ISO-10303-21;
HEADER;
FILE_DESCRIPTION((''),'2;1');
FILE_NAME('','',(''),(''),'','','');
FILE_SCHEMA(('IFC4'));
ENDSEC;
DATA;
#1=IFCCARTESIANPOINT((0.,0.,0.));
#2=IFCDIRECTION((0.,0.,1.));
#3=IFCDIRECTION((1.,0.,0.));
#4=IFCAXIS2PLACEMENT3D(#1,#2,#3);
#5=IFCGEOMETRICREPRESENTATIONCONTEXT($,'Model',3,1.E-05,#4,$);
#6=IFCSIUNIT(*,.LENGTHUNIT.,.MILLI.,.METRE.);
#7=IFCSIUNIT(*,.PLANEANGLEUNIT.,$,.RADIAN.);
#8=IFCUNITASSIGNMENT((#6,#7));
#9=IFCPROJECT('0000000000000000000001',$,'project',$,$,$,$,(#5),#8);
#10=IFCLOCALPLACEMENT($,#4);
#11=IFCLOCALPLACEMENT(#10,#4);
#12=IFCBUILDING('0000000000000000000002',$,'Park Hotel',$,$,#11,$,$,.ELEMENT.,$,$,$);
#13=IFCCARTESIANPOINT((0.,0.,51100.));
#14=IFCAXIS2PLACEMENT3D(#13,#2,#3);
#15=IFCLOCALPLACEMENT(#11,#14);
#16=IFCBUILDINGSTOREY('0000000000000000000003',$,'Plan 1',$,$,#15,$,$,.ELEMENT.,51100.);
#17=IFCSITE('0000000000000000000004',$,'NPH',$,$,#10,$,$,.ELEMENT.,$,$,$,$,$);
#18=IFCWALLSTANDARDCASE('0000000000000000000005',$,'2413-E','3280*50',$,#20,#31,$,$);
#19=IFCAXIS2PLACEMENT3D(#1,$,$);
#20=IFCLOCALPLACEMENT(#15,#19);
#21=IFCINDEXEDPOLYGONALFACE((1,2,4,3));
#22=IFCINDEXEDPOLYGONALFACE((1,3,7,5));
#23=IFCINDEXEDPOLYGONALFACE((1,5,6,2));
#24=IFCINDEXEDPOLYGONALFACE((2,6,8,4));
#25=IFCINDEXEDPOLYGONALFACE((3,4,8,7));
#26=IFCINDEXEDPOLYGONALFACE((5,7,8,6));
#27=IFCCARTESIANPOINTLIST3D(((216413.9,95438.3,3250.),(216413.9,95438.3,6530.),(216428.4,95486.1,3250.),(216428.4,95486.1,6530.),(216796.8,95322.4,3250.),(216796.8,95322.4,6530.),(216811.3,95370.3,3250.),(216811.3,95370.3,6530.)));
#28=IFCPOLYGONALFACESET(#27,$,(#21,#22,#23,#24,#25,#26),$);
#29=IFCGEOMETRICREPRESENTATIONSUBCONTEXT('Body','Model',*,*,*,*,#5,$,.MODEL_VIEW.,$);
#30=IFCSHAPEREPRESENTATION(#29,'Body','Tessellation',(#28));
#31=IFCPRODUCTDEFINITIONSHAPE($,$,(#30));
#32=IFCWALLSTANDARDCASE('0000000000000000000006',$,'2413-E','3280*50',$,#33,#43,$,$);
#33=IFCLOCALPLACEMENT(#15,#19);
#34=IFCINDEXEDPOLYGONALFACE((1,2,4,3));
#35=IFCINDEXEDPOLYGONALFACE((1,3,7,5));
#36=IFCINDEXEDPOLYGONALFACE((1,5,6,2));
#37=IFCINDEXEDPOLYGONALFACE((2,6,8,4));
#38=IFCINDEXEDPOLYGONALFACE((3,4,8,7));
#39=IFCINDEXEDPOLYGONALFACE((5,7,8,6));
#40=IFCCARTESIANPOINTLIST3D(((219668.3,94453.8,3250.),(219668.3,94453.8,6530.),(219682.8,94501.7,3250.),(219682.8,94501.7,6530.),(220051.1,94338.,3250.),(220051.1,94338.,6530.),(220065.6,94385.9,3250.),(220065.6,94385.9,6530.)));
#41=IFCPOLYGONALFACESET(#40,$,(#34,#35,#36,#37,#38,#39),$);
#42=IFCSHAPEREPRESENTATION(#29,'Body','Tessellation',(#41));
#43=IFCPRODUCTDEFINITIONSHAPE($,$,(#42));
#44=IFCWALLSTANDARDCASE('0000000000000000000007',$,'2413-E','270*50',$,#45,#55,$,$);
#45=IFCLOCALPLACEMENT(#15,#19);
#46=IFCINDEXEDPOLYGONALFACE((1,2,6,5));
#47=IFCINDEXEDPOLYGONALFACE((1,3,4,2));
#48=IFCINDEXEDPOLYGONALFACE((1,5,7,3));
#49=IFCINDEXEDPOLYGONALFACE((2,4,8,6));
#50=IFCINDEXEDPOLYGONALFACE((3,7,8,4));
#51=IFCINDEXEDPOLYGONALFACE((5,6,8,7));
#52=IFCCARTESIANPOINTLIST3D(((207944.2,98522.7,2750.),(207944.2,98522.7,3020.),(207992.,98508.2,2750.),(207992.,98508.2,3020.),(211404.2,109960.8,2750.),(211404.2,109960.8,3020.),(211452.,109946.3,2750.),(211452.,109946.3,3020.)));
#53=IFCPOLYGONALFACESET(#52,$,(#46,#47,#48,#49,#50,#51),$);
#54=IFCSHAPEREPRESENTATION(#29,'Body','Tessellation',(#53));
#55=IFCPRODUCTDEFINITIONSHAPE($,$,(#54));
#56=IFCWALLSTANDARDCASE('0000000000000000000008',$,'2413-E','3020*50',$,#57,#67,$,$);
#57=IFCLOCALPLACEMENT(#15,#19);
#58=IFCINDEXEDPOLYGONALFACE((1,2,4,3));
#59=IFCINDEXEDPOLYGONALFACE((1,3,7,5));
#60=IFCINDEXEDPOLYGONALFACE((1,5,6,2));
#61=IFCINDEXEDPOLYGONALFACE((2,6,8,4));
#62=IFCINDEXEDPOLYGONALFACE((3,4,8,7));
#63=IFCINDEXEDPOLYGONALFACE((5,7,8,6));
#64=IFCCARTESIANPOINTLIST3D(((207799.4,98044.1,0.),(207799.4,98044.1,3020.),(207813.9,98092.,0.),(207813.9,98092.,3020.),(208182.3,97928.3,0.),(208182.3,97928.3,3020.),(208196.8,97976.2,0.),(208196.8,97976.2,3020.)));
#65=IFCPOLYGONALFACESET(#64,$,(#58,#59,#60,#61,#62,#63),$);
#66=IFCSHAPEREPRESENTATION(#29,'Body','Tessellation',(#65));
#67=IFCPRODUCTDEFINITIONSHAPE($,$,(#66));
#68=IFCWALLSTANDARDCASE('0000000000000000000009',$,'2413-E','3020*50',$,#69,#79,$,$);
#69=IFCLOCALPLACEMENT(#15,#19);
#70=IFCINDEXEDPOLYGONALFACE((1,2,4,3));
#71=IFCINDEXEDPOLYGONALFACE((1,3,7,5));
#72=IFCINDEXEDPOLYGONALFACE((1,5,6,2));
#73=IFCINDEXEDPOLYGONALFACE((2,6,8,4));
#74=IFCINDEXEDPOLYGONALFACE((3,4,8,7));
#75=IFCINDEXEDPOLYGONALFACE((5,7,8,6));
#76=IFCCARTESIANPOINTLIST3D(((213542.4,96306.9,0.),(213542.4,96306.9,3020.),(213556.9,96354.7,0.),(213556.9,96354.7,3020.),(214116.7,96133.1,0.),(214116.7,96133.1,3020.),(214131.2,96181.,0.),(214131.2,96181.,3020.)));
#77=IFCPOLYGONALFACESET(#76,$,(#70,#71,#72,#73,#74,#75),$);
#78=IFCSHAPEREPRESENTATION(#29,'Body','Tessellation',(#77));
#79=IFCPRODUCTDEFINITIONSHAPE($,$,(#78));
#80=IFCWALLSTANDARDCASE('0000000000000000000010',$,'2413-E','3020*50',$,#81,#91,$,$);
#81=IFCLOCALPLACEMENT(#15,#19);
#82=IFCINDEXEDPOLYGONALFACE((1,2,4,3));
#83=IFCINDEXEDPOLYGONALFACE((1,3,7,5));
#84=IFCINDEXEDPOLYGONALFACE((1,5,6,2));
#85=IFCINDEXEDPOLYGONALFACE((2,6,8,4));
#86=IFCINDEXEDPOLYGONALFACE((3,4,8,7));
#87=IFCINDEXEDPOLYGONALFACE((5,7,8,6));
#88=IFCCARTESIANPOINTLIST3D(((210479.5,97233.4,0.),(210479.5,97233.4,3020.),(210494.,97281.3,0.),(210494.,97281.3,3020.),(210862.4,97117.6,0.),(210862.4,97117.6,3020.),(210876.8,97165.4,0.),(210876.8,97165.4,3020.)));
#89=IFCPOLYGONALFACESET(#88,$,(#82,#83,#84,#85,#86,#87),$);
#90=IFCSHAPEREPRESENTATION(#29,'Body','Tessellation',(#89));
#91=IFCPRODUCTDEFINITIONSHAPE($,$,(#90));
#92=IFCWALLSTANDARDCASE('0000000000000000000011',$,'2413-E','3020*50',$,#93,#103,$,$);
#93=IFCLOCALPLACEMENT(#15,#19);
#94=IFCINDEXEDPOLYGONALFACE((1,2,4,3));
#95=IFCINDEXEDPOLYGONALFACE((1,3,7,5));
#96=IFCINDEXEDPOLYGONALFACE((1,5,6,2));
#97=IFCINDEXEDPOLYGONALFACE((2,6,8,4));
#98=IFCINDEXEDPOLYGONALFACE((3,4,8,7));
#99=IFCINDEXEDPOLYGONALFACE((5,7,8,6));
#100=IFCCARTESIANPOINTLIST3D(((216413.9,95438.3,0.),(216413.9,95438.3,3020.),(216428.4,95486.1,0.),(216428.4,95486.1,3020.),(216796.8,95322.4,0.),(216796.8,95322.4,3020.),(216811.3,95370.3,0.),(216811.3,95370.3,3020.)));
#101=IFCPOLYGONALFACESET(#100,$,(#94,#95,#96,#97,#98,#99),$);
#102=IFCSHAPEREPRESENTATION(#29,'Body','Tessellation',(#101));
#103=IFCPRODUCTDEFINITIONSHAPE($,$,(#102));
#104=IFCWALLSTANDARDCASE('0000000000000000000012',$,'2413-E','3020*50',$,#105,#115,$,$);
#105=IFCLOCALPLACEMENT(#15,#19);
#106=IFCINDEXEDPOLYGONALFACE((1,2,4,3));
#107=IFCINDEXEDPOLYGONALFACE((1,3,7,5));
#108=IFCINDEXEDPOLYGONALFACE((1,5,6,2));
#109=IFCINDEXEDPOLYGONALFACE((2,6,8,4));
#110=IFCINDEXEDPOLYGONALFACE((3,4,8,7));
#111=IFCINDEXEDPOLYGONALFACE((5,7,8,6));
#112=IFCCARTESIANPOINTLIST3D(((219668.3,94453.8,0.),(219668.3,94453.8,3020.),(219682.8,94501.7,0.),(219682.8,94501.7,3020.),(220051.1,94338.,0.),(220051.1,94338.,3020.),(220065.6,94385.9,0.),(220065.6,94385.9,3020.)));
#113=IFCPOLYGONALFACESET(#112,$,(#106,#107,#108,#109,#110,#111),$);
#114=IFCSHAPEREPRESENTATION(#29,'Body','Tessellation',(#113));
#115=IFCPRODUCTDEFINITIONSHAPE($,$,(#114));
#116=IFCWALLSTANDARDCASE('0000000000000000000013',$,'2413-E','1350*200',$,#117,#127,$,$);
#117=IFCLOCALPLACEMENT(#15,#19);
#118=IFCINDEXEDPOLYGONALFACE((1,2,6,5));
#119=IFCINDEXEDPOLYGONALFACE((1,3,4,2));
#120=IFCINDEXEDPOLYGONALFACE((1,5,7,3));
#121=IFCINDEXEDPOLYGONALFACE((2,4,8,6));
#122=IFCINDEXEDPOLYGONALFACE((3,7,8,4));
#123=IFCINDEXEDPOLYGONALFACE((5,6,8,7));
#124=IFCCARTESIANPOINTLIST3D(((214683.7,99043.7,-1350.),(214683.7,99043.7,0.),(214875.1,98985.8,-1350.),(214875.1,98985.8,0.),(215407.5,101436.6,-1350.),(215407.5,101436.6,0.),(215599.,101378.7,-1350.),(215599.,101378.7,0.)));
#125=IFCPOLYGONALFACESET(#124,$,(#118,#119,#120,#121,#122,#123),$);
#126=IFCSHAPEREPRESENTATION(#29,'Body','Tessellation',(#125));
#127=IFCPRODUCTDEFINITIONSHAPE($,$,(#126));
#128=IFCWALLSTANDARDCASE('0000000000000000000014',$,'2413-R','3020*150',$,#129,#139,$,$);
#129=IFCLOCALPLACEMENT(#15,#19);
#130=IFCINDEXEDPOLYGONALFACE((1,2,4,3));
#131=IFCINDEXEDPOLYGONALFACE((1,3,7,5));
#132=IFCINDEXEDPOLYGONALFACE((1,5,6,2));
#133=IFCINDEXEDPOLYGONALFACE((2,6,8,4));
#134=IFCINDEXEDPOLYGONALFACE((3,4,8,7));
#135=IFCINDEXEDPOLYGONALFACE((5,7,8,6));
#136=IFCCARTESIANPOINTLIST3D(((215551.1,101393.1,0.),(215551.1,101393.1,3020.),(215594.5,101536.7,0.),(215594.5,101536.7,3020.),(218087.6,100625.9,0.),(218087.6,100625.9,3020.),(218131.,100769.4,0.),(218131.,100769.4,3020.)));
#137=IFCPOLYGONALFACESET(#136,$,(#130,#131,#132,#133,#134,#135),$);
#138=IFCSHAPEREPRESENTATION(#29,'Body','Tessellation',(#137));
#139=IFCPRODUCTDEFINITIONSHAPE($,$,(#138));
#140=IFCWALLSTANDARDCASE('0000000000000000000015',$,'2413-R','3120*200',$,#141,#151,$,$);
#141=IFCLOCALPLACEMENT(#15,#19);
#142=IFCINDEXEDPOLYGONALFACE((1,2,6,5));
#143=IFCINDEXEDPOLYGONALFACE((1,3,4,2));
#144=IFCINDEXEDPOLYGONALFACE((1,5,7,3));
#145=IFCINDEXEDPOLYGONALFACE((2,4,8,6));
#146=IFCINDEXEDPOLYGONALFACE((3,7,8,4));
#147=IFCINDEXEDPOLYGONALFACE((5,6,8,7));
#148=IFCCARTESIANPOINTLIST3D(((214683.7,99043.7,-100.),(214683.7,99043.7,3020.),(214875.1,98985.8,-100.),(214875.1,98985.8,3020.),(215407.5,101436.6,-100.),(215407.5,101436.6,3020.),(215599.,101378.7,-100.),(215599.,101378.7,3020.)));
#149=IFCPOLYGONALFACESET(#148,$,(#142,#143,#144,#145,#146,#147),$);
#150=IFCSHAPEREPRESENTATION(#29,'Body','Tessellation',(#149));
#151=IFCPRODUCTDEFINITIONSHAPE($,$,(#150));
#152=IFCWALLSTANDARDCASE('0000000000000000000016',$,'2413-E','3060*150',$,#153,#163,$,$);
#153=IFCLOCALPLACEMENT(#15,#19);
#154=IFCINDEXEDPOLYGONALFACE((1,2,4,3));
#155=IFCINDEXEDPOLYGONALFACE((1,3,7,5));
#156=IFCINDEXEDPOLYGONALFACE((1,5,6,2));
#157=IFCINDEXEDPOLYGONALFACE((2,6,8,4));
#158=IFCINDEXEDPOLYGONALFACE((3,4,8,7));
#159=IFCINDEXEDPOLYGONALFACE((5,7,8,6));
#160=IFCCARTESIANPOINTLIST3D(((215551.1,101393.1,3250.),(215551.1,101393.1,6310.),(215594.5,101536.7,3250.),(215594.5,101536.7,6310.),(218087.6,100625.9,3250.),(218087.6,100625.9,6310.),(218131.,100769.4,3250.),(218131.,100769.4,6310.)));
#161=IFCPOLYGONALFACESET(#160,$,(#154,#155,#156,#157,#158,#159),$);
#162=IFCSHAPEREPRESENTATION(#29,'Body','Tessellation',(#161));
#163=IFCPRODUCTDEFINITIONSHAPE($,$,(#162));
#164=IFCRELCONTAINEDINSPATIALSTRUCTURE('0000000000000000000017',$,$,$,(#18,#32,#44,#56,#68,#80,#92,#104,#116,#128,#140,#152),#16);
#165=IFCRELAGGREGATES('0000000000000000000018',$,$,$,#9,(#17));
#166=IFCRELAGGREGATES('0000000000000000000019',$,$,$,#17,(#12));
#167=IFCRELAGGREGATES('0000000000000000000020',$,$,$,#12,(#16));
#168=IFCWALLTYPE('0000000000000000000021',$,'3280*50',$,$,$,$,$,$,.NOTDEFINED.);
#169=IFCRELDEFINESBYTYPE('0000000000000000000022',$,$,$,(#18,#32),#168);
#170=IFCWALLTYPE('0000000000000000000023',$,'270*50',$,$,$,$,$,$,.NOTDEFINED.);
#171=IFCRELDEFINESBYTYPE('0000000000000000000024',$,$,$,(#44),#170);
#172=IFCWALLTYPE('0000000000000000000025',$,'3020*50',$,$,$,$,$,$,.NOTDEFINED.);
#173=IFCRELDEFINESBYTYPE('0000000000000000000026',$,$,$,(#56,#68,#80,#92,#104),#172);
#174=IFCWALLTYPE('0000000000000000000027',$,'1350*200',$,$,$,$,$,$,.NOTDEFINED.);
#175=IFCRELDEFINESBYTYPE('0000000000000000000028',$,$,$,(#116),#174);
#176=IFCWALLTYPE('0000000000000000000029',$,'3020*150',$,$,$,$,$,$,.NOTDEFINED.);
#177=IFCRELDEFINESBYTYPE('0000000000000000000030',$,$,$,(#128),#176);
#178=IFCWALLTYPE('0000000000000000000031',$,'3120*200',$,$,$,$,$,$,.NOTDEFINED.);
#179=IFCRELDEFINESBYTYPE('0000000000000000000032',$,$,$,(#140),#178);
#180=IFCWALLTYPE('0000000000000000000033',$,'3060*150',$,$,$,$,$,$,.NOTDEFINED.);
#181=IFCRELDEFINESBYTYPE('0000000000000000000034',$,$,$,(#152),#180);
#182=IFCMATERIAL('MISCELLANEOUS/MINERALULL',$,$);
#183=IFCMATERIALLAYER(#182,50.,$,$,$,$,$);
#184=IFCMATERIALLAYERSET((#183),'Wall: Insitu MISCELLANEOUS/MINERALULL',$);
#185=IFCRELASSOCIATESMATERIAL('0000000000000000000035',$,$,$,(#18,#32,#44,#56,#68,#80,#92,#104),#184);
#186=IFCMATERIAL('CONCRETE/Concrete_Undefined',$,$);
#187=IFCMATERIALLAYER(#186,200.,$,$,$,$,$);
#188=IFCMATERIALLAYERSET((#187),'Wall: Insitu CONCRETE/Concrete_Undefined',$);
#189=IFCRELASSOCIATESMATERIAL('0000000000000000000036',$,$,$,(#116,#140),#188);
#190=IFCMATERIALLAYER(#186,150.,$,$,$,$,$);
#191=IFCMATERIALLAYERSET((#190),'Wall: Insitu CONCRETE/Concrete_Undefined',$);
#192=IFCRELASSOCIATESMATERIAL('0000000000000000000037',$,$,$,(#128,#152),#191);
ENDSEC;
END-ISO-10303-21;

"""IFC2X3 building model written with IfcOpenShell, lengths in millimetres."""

from ifc_helpers import new_model, si_unit, frame, frame_2d, origin_with_axes, place, context, subcontext, project, spatial, rectangle, extrude, material, layer, layer_set, layer_usage, type_object, element, save


model = new_model("IFC2X3")

# Units and contexts
model_context = context("Model", 3, precision=1e-05, world=origin_with_axes())
body_context = subcontext(model_context, "Body", "Model", "MODEL_VIEW")
ifc_project = project(units=[si_unit("LENGTHUNIT", "METRE", prefix="MILLI"), si_unit("PLANEANGLEUNIT", "RADIAN")], contexts=[model_context])

# Site, building, storey
site_placement = place(None, origin_with_axes())
site = spatial("IfcSite", under=ifc_project, at=site_placement, Name="NPH", CompositionType="ELEMENT")
building_placement = place(site_placement, origin_with_axes())
building = spatial("IfcBuilding", under=site, at=building_placement, Name="Park Hotel", CompositionType="ELEMENT")
storey_placement = place(building_placement, frame((0.0, 0.0, 51100.0), z_axis=(0.0, 0.0, 1.0), x_axis=(1.0, 0.0, 0.0)))
storey = spatial("IfcBuildingStorey", under=building, at=storey_placement, Name="Plan 1", CompositionType="ELEMENT", Elevation=51100.0)

# Shared definitions
ifc_material_1 = material(Name="CONCRETE/Concrete_Undefined")

# Walls
ifc_material_2 = material(Name="MISCELLANEOUS/MINERALULL")
ifc_layer_1 = layer(ifc_material_2, 50.0)
ifc_layer_set_1 = layer_set([ifc_layer_1], Name="Wall: Insitu MISCELLANEOUS/MINERALULL")
wall_type_1 = type_object("IfcWallType", Name="3280*50", PredefinedType="NOTDEFINED")
ifc_layer_usage_1 = layer_usage(ifc_layer_set_1, "AXIS2", "POSITIVE", -25.0)
wall_1_placement = place(storey_placement, frame((216421.2, 95462.2, 3250.0), z_axis=(0.0, 0.0, 1.0), x_axis=(0.957166, -0.289539, 0.0)))
element("IfcWallStandardCase", 1, at=wall_1_placement, inside=storey, type_object=wall_type_1, material=ifc_layer_usage_1, Name="2413-E", Description="3280*50", context=body_context, shape_type="SweptSolid", body=[
    extrude(rectangle(XDim=400.0, YDim=50.0, at=frame_2d((0.0, 200.0), x_axis=(0.0, -1.0))), frame((0.0, 0.0, 0.0), z_axis=(0.0, 0.0, 1.0), x_axis=(0.0, -1.0, 0.0)), (0.0, 0.0, 1.0), 3280.0),
])
ifc_layer_usage_2 = layer_usage(ifc_layer_set_1, "AXIS2", "POSITIVE", -25.0)
wall_2_placement = place(storey_placement, frame((219675.5, 94477.8, 3250.0), z_axis=(0.0, 0.0, 1.0), x_axis=(0.957166, -0.289539, 0.0)))
element("IfcWallStandardCase", 2, at=wall_2_placement, inside=storey, type_object=wall_type_1, material=ifc_layer_usage_2, Name="2413-E", Description="3280*50", context=body_context, shape_type="SweptSolid", body=[
    extrude(rectangle(XDim=400.0, YDim=50.0, at=frame_2d((0.0, 200.0), x_axis=(0.0, -1.0))), frame((0.0, 0.0, 0.0), z_axis=(0.0, 0.0, 1.0), x_axis=(0.0, -1.0, 0.0)), (0.0, 0.0, 1.0), 3280.0),
])
ifc_layer_usage_3 = layer_usage(ifc_layer_set_1, "AXIS2", "POSITIVE", -25.0)
wall_type_2 = type_object("IfcWallType", Name="270*50", PredefinedType="NOTDEFINED")
wall_3_placement = place(storey_placement, frame((207968.1, 98515.4, 2750.0), z_axis=(0.0, 0.0, 1.0), x_axis=(0.289538, 0.957167, 0.0)))
element("IfcWallStandardCase", 3, at=wall_3_placement, inside=storey, type_object=wall_type_2, material=ifc_layer_usage_3, Name="2413-E", Description="270*50", context=body_context, shape_type="SweptSolid", body=[
    extrude(rectangle(XDim=11950.0, YDim=50.0, at=frame_2d((0.0, 5975.0), x_axis=(0.0, -1.0))), frame((0.0, 0.0, 0.0), z_axis=(0.0, 0.0, 1.0), x_axis=(0.0, -1.0, 0.0)), (0.0, 0.0, 1.0), 270.0),
])
ifc_layer_usage_4 = layer_usage(ifc_layer_set_1, "AXIS2", "POSITIVE", -25.0)
wall_type_3 = type_object("IfcWallType", Name="3020*50", PredefinedType="NOTDEFINED")
wall_4_placement = place(storey_placement, frame((207806.6, 98068.0, 0.0), z_axis=(0.0, 0.0, 1.0), x_axis=(0.957166, -0.289539, 0.0)))
element("IfcWallStandardCase", 4, at=wall_4_placement, inside=storey, type_object=wall_type_3, material=ifc_layer_usage_4, Name="2413-E", Description="3020*50", context=body_context, shape_type="SweptSolid", body=[
    extrude(rectangle(XDim=400.0, YDim=50.0, at=frame_2d((0.0, 200.0), x_axis=(0.0, -1.0))), frame((0.0, 0.0, 0.0), z_axis=(0.0, 0.0, 1.0), x_axis=(0.0, -1.0, 0.0)), (0.0, 0.0, 1.0), 3020.0),
])
ifc_layer_usage_5 = layer_usage(ifc_layer_set_1, "AXIS2", "POSITIVE", -25.0)
wall_5_placement = place(storey_placement, frame((213549.7, 96330.8, 0.0), z_axis=(0.0, 0.0, 1.0), x_axis=(0.957166, -0.289539, 0.0)))
element("IfcWallStandardCase", 5, at=wall_5_placement, inside=storey, type_object=wall_type_3, material=ifc_layer_usage_5, Name="2413-E", Description="3020*50", context=body_context, shape_type="SweptSolid", body=[
    extrude(rectangle(XDim=600.0, YDim=50.0, at=frame_2d((0.0, 300.0), x_axis=(0.0, -1.0))), frame((0.0, 0.0, 0.0), z_axis=(0.0, 0.0, 1.0), x_axis=(0.0, -1.0, 0.0)), (0.0, 0.0, 1.0), 3020.0),
])
ifc_layer_usage_6 = layer_usage(ifc_layer_set_1, "AXIS2", "POSITIVE", -25.0)
wall_6_placement = place(storey_placement, frame((210486.7, 97257.3, 0.0), z_axis=(0.0, 0.0, 1.0), x_axis=(0.957166, -0.289539, 0.0)))
element("IfcWallStandardCase", 6, at=wall_6_placement, inside=storey, type_object=wall_type_3, material=ifc_layer_usage_6, Name="2413-E", Description="3020*50", context=body_context, shape_type="SweptSolid", body=[
    extrude(rectangle(XDim=400.0, YDim=50.0, at=frame_2d((0.0, 200.0), x_axis=(0.0, -1.0))), frame((0.0, 0.0, 0.0), z_axis=(0.0, 0.0, 1.0), x_axis=(0.0, -1.0, 0.0)), (0.0, 0.0, 1.0), 3020.0),
])
ifc_layer_usage_7 = layer_usage(ifc_layer_set_1, "AXIS2", "POSITIVE", -25.0)
wall_7_placement = place(storey_placement, frame((216421.2, 95462.2, 0.0), z_axis=(0.0, 0.0, 1.0), x_axis=(0.957166, -0.289539, 0.0)))
element("IfcWallStandardCase", 7, at=wall_7_placement, inside=storey, type_object=wall_type_3, material=ifc_layer_usage_7, Name="2413-E", Description="3020*50", context=body_context, shape_type="SweptSolid", body=[
    extrude(rectangle(XDim=400.0, YDim=50.0, at=frame_2d((0.0, 200.0), x_axis=(0.0, -1.0))), frame((0.0, 0.0, 0.0), z_axis=(0.0, 0.0, 1.0), x_axis=(0.0, -1.0, 0.0)), (0.0, 0.0, 1.0), 3020.0),
])
ifc_layer_usage_8 = layer_usage(ifc_layer_set_1, "AXIS2", "POSITIVE", -25.0)
wall_8_placement = place(storey_placement, frame((219675.5, 94477.8, 0.0), z_axis=(0.0, 0.0, 1.0), x_axis=(0.957166, -0.289539, 0.0)))
element("IfcWallStandardCase", 8, at=wall_8_placement, inside=storey, type_object=wall_type_3, material=ifc_layer_usage_8, Name="2413-E", Description="3020*50", context=body_context, shape_type="SweptSolid", body=[
    extrude(rectangle(XDim=400.0, YDim=50.0, at=frame_2d((0.0, 200.0), x_axis=(0.0, -1.0))), frame((0.0, 0.0, 0.0), z_axis=(0.0, 0.0, 1.0), x_axis=(0.0, -1.0, 0.0)), (0.0, 0.0, 1.0), 3020.0),
])
ifc_layer_2 = layer(ifc_material_1, 200.0)
ifc_layer_set_2 = layer_set([ifc_layer_2], Name="Wall: Insitu CONCRETE/Concrete_Undefined")
ifc_layer_usage_9 = layer_usage(ifc_layer_set_2, "AXIS2", "POSITIVE", -100.0)
wall_type_4 = type_object("IfcWallType", Name="1350*200", PredefinedType="NOTDEFINED")
wall_9_placement = place(storey_placement, frame((214779.4, 99014.7, -1350.0), z_axis=(0.0, 0.0, 1.0), x_axis=(0.289536, 0.957167, 0.0)))
element("IfcWallStandardCase", 9, at=wall_9_placement, inside=storey, type_object=wall_type_4, material=ifc_layer_usage_9, Name="2413-E", Description="1350*200", context=body_context, shape_type="SweptSolid", body=[
    extrude(rectangle(XDim=2500.0, YDim=200.0, at=frame_2d((0.0, 1250.0), x_axis=(0.0, -1.0))), frame((0.0, 0.0, 0.0), z_axis=(0.0, 0.0, 1.0), x_axis=(0.0, -1.0, 0.0)), (0.0, 0.0, 1.0), 1350.0),
])
ifc_layer_3 = layer(ifc_material_1, 150.0)
ifc_layer_set_3 = layer_set([ifc_layer_3], Name="Wall: Insitu CONCRETE/Concrete_Undefined")
ifc_layer_usage_10 = layer_usage(ifc_layer_set_3, "AXIS2", "POSITIVE", -75.0)
wall_type_5 = type_object("IfcWallType", Name="3020*150", PredefinedType="NOTDEFINED")
wall_10_placement = place(storey_placement, frame((218109.3, 100697.7, 0.0), z_axis=(0.0, 0.0, 1.0), x_axis=(-0.957167, 0.289537, 0.0)))
element("IfcWallStandardCase", 10, at=wall_10_placement, inside=storey, type_object=wall_type_5, material=ifc_layer_usage_10, Name="2413-R", Description="3020*150", context=body_context, shape_type="SweptSolid", body=[
    extrude(rectangle(XDim=2650.0, YDim=150.0, at=frame_2d((0.0, 1325.0), x_axis=(0.0, -1.0))), frame((0.0, 0.0, 0.0), z_axis=(0.0, 0.0, 1.0), x_axis=(0.0, -1.0, 0.0)), (0.0, 0.0, 1.0), 3020.0),
])
ifc_layer_usage_11 = layer_usage(ifc_layer_set_2, "AXIS2", "POSITIVE", -100.0)
wall_type_6 = type_object("IfcWallType", Name="3120*200", PredefinedType="NOTDEFINED")
wall_11_placement = place(storey_placement, frame((214779.4, 99014.7, -100.0), z_axis=(0.0, 0.0, 1.0), x_axis=(0.289536, 0.957167, 0.0)))
element("IfcWallStandardCase", 11, at=wall_11_placement, inside=storey, type_object=wall_type_6, material=ifc_layer_usage_11, Name="2413-R", Description="3120*200", context=body_context, shape_type="SweptSolid", body=[
    extrude(rectangle(XDim=2500.0, YDim=200.0, at=frame_2d((0.0, 1250.0), x_axis=(0.0, -1.0))), frame((0.0, 0.0, 0.0), z_axis=(0.0, 0.0, 1.0), x_axis=(0.0, -1.0, 0.0)), (0.0, 0.0, 1.0), 3120.0),
])
ifc_layer_usage_12 = layer_usage(ifc_layer_set_3, "AXIS2", "POSITIVE", -75.0)
wall_type_7 = type_object("IfcWallType", Name="3060*150", PredefinedType="NOTDEFINED")
wall_12_placement = place(storey_placement, frame((218109.3, 100697.7, 3250.0), z_axis=(0.0, 0.0, 1.0), x_axis=(-0.957167, 0.289537, 0.0)))
element("IfcWallStandardCase", 12, at=wall_12_placement, inside=storey, type_object=wall_type_7, material=ifc_layer_usage_12, Name="2413-E", Description="3060*150", context=body_context, shape_type="SweptSolid", body=[
    extrude(rectangle(XDim=2650.0, YDim=150.0, at=frame_2d((0.0, 1325.0), x_axis=(0.0, -1.0))), frame((0.0, 0.0, 0.0), z_axis=(0.0, 0.0, 1.0), x_axis=(0.0, -1.0, 0.0)), (0.0, 0.0, 1.0), 3060.0),
])

save(model, "model.ifc")
